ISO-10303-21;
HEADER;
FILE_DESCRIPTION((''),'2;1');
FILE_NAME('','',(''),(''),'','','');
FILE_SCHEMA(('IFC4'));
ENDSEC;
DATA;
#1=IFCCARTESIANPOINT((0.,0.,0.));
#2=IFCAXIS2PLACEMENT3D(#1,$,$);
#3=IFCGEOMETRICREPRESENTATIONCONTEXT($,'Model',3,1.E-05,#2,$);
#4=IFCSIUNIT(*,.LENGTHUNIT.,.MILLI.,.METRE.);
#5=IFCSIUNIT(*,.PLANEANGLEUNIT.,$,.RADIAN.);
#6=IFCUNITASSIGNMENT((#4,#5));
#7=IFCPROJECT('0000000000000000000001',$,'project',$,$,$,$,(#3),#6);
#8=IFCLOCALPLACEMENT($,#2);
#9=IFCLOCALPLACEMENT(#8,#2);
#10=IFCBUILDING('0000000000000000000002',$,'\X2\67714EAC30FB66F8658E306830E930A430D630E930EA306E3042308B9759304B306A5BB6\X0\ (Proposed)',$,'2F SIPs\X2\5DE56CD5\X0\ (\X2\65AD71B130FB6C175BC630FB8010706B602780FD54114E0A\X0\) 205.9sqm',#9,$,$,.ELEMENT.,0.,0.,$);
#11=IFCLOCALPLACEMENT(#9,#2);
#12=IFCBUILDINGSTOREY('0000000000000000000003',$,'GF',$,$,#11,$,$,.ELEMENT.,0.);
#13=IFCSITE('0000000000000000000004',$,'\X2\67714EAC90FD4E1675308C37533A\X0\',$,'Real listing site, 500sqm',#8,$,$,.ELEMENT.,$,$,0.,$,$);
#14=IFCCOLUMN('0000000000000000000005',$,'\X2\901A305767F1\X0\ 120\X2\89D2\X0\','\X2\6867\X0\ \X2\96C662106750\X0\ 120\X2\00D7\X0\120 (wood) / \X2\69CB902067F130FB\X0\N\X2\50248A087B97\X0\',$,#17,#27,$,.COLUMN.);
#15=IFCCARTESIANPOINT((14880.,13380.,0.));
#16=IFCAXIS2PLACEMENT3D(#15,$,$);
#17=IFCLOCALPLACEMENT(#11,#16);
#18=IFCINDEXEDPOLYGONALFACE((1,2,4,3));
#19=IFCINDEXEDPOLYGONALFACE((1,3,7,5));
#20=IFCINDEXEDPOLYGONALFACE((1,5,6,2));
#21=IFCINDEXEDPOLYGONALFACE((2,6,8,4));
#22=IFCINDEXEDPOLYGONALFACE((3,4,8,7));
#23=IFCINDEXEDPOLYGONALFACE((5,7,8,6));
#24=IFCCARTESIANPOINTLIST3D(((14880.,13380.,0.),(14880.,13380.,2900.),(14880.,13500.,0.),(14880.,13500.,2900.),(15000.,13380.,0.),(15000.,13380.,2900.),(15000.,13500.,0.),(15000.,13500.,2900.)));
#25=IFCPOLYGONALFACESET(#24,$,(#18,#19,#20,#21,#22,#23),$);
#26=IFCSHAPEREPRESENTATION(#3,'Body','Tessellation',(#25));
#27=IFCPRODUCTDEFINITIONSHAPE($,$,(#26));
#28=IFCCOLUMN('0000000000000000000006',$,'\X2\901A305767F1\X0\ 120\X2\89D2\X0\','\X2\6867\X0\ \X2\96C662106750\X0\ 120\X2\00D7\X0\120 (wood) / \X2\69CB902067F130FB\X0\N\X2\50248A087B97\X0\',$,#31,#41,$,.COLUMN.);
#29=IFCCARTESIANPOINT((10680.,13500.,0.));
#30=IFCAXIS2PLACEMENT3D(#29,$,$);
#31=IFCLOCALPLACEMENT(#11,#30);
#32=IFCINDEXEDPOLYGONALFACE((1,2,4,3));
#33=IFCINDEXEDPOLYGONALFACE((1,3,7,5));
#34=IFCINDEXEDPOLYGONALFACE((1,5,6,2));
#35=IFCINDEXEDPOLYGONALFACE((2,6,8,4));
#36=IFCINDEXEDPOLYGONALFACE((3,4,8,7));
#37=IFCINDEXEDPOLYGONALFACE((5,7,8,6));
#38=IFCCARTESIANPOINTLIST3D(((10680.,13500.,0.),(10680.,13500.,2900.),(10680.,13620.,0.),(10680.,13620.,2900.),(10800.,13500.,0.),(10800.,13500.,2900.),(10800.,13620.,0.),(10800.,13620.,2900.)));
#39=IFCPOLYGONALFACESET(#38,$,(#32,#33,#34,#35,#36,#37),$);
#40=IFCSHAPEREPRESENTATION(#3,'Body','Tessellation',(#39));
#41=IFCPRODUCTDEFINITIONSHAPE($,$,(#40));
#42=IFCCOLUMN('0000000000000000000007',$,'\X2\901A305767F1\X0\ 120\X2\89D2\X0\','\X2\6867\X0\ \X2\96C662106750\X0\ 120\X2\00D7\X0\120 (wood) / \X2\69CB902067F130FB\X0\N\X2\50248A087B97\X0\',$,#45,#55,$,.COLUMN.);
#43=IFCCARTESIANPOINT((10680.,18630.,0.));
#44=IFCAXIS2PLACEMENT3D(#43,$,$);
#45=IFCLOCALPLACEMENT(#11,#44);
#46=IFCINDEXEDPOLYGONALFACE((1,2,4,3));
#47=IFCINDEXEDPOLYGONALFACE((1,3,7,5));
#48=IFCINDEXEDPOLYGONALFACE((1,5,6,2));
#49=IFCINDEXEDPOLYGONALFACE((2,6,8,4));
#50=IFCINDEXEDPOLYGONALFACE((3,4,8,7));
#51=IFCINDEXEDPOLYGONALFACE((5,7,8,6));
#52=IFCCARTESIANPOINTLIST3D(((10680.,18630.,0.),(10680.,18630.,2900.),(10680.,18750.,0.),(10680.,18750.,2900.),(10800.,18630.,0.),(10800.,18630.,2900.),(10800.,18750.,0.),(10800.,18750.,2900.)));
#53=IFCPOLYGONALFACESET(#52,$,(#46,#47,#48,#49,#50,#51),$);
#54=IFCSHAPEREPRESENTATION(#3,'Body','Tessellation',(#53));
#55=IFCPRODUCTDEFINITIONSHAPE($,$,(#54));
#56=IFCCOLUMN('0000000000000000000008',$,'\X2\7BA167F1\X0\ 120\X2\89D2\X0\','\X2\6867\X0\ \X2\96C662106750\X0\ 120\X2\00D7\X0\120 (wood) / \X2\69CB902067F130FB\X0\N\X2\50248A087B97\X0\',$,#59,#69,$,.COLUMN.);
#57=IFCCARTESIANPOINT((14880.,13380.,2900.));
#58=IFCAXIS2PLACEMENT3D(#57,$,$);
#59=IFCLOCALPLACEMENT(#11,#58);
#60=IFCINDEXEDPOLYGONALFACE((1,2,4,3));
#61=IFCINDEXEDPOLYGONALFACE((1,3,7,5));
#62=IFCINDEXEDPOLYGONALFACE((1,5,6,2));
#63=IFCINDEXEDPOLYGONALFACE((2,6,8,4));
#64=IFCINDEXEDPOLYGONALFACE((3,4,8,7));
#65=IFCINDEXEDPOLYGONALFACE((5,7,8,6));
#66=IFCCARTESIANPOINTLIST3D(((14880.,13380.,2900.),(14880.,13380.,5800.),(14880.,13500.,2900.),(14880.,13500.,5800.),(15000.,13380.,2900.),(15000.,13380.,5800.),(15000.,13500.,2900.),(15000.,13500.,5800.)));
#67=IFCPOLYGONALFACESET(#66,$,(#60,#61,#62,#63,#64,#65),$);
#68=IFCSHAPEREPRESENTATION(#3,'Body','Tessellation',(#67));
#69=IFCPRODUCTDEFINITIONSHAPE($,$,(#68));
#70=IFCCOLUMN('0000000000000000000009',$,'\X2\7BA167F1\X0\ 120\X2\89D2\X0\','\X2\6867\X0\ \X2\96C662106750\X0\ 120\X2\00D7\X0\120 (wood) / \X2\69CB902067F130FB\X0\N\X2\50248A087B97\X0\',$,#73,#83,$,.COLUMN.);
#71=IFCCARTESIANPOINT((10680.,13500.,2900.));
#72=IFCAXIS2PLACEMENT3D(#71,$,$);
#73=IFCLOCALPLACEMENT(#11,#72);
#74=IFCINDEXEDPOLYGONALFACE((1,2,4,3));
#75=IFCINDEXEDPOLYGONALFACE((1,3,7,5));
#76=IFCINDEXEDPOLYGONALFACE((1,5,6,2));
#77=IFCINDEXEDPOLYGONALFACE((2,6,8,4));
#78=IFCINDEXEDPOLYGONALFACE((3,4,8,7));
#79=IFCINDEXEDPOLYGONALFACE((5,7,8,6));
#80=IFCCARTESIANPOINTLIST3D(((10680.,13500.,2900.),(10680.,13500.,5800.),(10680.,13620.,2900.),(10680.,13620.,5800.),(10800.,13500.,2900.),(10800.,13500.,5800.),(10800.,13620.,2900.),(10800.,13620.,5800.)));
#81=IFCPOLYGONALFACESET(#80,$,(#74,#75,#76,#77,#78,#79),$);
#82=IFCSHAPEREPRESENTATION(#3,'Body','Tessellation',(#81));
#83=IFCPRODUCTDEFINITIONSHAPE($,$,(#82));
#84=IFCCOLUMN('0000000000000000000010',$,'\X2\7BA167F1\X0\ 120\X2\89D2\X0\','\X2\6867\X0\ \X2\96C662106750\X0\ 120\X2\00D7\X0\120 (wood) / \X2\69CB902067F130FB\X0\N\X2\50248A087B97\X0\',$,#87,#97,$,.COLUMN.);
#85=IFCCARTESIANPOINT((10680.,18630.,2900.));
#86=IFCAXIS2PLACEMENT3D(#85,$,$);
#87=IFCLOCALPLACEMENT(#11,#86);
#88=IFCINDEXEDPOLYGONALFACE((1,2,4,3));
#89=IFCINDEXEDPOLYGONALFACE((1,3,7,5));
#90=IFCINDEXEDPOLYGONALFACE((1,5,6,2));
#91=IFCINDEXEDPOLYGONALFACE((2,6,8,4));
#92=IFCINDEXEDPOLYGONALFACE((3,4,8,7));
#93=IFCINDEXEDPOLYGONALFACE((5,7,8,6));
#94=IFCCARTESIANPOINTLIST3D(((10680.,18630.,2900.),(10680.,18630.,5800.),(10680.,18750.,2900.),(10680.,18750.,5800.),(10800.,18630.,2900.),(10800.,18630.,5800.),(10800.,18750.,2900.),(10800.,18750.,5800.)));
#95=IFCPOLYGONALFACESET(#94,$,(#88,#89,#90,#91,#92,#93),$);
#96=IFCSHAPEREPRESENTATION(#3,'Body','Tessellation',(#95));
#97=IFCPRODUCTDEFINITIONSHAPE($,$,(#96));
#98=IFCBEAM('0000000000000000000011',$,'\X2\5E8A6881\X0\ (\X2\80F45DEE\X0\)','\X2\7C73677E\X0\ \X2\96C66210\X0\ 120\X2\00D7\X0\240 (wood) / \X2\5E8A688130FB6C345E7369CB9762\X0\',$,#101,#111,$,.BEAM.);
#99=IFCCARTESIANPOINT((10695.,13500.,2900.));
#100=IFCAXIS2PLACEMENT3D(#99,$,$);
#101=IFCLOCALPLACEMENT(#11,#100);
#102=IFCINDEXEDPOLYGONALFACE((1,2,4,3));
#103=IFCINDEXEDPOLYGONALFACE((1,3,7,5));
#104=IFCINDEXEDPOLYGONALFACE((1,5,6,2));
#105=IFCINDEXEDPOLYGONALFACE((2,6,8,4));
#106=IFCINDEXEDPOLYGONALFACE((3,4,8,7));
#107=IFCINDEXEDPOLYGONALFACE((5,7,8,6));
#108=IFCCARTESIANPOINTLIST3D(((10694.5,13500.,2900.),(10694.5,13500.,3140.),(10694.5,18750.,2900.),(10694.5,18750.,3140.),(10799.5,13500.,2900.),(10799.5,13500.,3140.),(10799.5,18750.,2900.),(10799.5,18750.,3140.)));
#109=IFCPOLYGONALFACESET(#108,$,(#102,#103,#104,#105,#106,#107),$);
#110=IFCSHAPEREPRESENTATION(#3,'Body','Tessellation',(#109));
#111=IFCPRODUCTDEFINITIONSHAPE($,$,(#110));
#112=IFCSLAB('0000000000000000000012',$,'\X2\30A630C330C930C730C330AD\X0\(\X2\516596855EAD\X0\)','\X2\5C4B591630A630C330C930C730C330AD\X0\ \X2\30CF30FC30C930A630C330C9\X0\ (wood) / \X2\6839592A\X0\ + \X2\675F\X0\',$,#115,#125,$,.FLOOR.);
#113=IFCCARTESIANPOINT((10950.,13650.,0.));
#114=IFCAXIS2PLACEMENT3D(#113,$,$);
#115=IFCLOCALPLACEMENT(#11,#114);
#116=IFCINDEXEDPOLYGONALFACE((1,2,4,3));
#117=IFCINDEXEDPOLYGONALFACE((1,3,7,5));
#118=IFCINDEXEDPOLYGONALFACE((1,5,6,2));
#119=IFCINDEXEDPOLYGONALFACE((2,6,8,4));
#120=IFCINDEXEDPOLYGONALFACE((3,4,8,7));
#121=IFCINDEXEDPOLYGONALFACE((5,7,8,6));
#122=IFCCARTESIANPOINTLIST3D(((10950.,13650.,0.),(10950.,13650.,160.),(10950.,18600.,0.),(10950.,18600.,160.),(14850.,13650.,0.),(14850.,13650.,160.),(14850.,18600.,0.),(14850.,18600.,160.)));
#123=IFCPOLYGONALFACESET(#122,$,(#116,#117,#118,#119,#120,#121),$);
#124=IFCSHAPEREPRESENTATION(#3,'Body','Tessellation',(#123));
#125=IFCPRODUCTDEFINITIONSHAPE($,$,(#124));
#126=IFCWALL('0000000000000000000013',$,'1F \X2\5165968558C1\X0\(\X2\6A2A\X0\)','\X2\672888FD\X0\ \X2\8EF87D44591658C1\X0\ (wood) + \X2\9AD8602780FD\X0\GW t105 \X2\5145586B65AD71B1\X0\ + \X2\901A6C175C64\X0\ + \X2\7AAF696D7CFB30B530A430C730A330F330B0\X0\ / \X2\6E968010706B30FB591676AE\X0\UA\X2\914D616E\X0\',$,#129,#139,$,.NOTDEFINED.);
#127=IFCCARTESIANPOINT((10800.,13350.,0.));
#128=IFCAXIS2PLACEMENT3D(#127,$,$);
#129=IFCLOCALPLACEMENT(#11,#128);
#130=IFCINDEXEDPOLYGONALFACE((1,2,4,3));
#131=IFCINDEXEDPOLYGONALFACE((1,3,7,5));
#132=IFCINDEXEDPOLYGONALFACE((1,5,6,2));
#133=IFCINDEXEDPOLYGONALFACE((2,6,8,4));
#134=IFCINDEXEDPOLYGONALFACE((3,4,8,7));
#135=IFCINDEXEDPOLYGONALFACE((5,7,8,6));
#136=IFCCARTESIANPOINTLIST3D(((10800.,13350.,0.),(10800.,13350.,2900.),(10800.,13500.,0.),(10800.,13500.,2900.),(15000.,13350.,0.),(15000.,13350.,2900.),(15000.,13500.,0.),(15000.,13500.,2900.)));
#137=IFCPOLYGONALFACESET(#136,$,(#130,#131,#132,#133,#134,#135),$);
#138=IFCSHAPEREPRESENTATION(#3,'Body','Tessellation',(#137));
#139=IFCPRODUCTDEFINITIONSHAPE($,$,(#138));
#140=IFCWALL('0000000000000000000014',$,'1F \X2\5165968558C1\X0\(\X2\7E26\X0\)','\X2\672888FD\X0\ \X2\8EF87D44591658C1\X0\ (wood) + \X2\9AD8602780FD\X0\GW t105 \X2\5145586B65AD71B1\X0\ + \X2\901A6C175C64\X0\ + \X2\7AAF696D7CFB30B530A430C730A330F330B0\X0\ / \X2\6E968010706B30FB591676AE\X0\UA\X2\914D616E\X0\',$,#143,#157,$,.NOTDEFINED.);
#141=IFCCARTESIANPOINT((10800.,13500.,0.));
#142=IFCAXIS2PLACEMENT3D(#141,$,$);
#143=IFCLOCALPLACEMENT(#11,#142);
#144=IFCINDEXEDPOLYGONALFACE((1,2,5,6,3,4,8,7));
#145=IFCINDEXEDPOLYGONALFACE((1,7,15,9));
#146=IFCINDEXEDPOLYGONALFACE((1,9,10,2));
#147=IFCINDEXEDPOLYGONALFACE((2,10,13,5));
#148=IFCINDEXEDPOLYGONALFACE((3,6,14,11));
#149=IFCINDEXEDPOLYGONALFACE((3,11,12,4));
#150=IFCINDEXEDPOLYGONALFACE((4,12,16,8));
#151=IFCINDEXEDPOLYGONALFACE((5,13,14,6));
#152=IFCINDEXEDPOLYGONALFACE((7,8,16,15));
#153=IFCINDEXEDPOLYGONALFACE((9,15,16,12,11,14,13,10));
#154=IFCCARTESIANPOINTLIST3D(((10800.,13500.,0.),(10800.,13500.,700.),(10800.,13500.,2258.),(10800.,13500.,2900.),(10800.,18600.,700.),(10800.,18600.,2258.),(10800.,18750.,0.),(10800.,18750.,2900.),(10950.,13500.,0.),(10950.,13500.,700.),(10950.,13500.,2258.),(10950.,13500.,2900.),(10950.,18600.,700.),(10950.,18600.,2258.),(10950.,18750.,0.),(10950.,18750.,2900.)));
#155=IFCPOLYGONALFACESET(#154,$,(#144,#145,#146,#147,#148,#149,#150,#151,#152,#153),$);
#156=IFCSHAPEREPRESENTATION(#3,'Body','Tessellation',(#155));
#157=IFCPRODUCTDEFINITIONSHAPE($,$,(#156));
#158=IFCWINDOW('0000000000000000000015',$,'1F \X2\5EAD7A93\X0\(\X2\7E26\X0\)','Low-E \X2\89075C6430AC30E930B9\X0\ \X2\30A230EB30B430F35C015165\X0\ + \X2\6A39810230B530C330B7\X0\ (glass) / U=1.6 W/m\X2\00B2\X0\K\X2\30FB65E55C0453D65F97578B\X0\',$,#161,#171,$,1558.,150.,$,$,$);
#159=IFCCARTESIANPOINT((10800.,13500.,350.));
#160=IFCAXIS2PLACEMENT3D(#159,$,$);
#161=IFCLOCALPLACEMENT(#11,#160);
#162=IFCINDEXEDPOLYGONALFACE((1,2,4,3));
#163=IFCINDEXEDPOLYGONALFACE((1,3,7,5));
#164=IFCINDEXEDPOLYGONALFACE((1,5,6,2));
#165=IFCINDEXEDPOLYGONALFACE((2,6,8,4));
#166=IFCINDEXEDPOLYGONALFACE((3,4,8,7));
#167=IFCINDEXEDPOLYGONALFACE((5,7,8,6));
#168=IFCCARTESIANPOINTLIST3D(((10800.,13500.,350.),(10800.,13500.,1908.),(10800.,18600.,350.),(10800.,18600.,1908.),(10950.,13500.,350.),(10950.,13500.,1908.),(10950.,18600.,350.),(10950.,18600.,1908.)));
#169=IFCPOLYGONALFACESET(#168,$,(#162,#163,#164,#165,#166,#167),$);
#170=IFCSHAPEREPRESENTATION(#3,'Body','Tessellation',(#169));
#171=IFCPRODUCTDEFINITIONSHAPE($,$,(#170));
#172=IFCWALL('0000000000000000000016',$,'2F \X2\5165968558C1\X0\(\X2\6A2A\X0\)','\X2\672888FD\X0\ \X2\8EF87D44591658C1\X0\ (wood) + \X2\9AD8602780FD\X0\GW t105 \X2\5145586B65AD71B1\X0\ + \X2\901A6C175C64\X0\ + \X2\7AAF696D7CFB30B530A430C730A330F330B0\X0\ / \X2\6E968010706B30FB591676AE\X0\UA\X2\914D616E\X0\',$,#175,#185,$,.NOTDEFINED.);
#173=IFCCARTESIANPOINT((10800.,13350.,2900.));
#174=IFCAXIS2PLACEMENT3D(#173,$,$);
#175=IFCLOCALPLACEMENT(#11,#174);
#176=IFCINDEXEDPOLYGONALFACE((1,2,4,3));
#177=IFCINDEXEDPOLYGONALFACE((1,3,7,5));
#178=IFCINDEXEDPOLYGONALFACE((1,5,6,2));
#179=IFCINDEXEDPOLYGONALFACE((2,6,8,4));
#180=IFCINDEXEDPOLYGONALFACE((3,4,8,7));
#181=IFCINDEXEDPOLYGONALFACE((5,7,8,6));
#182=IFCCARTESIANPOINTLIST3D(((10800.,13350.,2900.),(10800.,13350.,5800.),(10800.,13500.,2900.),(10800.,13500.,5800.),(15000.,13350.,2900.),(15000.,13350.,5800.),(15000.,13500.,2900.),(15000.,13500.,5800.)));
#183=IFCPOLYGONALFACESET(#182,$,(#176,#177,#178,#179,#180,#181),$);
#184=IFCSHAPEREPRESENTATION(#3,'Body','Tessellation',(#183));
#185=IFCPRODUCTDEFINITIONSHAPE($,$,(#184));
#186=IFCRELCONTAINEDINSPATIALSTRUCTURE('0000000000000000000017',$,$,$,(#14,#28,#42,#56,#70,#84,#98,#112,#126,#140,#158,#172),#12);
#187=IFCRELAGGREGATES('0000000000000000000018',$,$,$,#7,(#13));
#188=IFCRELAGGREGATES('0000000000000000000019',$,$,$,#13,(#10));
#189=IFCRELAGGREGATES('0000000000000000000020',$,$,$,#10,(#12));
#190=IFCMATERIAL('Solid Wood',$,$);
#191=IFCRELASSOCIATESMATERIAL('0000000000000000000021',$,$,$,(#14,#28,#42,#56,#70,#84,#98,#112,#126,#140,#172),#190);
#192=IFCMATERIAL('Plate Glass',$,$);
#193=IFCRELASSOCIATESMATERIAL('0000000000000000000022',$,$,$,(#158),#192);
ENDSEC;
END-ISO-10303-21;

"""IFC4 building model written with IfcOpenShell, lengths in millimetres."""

from ifc_helpers import new_model, si_unit, frame, frame_2d, origin, place, context, project, spatial, rectangle, extrude, material, element, fill, save


model = new_model("IFC4")

# Units and contexts
model_context = context("Model", 3, precision=1e-05, world=origin())
ifc_project = project(units=[si_unit("LENGTHUNIT", "METRE", prefix="MILLI"), si_unit("PLANEANGLEUNIT", "RADIAN")], contexts=[model_context])

# Site, building, storey
site_placement = place(None, origin())
site = spatial("IfcSite", under=ifc_project, at=site_placement, Name="東京都世田谷区", ObjectType="Real listing site, 500sqm", CompositionType="ELEMENT", RefElevation=0.0)
building_placement = place(site_placement, origin())
building = spatial("IfcBuilding", under=site, at=building_placement, Name="東京・書斎とライブラリのある静かな家 (Proposed)", ObjectType="2F SIPs工法 (断熱・気密・耐火性能向上) 205.9sqm", CompositionType="ELEMENT", ElevationOfRefHeight=0.0, ElevationOfTerrain=0.0)
storey_placement = place(building_placement, origin())
storey = spatial("IfcBuildingStorey", under=building, at=storey_placement, Name="GF", CompositionType="ELEMENT", Elevation=0.0)

# Columns
ifc_material_1 = material(Name="Solid Wood")
column_1_placement = place(storey_placement, frame((14880.0, 13380.0, 0.0)))
element("IfcColumn", 1, at=column_1_placement, inside=storey, material=ifc_material_1, Name="通し柱 120角", Description="桧 集成材 120×120 (wood) / 構造柱・N値計算", PredefinedType="COLUMN", context=model_context, shape_type="SweptSolid", body=[
    extrude(rectangle(XDim=120.0, YDim=120.0, at=frame_2d((60.0, 60.0))), frame((14880.0, 13380.0, 0.0)), (0.0, 0.0, 1.0), 2900.0),
])
column_2_placement = place(storey_placement, frame((10680.0, 13500.0, 0.0)))
element("IfcColumn", 2, at=column_2_placement, inside=storey, material=ifc_material_1, Name="通し柱 120角", Description="桧 集成材 120×120 (wood) / 構造柱・N値計算", PredefinedType="COLUMN", context=model_context, shape_type="SweptSolid", body=[
    extrude(rectangle(XDim=120.0, YDim=120.0, at=frame_2d((60.0, 60.0))), frame((10680.0, 13500.0, 0.0)), (0.0, 0.0, 1.0), 2900.0),
])
column_3_placement = place(storey_placement, frame((10680.0, 18630.0, 0.0)))
element("IfcColumn", 3, at=column_3_placement, inside=storey, material=ifc_material_1, Name="通し柱 120角", Description="桧 集成材 120×120 (wood) / 構造柱・N値計算", PredefinedType="COLUMN", context=model_context, shape_type="SweptSolid", body=[
    extrude(rectangle(XDim=120.0, YDim=120.0, at=frame_2d((60.0, 60.0))), frame((10680.0, 18630.0, 0.0)), (0.0, 0.0, 1.0), 2900.0),
])
column_4_placement = place(storey_placement, frame((14880.0, 13380.0, 2900.0)))
element("IfcColumn", 4, at=column_4_placement, inside=storey, material=ifc_material_1, Name="管柱 120角", Description="桧 集成材 120×120 (wood) / 構造柱・N値計算", PredefinedType="COLUMN", context=model_context, shape_type="SweptSolid", body=[
    extrude(rectangle(XDim=120.0, YDim=120.0, at=frame_2d((60.0, 60.0))), frame((14880.0, 13380.0, 2900.0)), (0.0, 0.0, 1.0), 2900.0),
])
column_5_placement = place(storey_placement, frame((10680.0, 13500.0, 2900.0)))
element("IfcColumn", 5, at=column_5_placement, inside=storey, material=ifc_material_1, Name="管柱 120角", Description="桧 集成材 120×120 (wood) / 構造柱・N値計算", PredefinedType="COLUMN", context=model_context, shape_type="SweptSolid", body=[
    extrude(rectangle(XDim=120.0, YDim=120.0, at=frame_2d((60.0, 60.0))), frame((10680.0, 13500.0, 2900.0)), (0.0, 0.0, 1.0), 2900.0),
])
column_6_placement = place(storey_placement, frame((10680.0, 18630.0, 2900.0)))
element("IfcColumn", 6, at=column_6_placement, inside=storey, material=ifc_material_1, Name="管柱 120角", Description="桧 集成材 120×120 (wood) / 構造柱・N値計算", PredefinedType="COLUMN", context=model_context, shape_type="SweptSolid", body=[
    extrude(rectangle(XDim=120.0, YDim=120.0, at=frame_2d((60.0, 60.0))), frame((10680.0, 18630.0, 2900.0)), (0.0, 0.0, 1.0), 2900.0),
])

# Beam
beam_1_placement = place(storey_placement, frame((10695.0, 13500.0, 2900.0)))
element("IfcBeam", 7, at=beam_1_placement, inside=storey, material=ifc_material_1, Name="床梁 (胴差)", Description="米松 集成 120×240 (wood) / 床梁・水平構面", PredefinedType="BEAM", context=model_context, shape_type="SweptSolid", body=[
    extrude(rectangle(XDim=105.0, YDim=5250.0, at=frame_2d((52.0, 2625.0))), frame((10695.0, 13500.0, 2900.0)), (0.0, 0.0, 1.0), 240.0),
])

# Slab
slab_placement = place(storey_placement, frame((10950.0, 13650.0, 0.0)))
element("IfcSlab", 8, at=slab_placement, inside=storey, material=ifc_material_1, Name="ウッドデッキ(入隅庭)", Description="屋外ウッドデッキ ハードウッド (wood) / 根太 + 束", PredefinedType="FLOOR", context=model_context, shape_type="SweptSolid", body=[
    extrude(rectangle(XDim=3900.0, YDim=4950.0, at=frame_2d((1950.0, 2475.0))), frame((10950.0, 13650.0, 0.0)), (0.0, 0.0, 1.0), 160.0),
])

# Wall
wall_1_placement = place(storey_placement, frame((10800.0, 13350.0, 0.0)))
element("IfcWall", 9, at=wall_1_placement, inside=storey, material=ifc_material_1, Name="1F 入隅壁(横)", Description="木製 軸組外壁 (wood) + 高性能GW t105 充填断熱 + 通気層 + 窯業系サイディング / 準耐火・外皮UA配慮", PredefinedType="NOTDEFINED", context=model_context, shape_type="SweptSolid", body=[
    extrude(rectangle(XDim=4200.0, YDim=150.0, at=frame_2d((2100.0, 75.0))), frame((10800.0, 13350.0, 0.0)), (0.0, 0.0, 1.0), 2900.0),
])

# Wall, opening, window
wall_2_placement = place(storey_placement, frame((10800.0, 13500.0, 0.0)))
wall_2 = element("IfcWall", 10, at=wall_2_placement, inside=storey, material=ifc_material_1, Name="1F 入隅壁(縦)", Description="木製 軸組外壁 (wood) + 高性能GW t105 充填断熱 + 通気層 + 窯業系サイディング / 準耐火・外皮UA配慮", PredefinedType="NOTDEFINED", context=model_context, shape_type="SweptSolid", body=[
    extrude(rectangle(XDim=150.0, YDim=5250.0, at=frame_2d((75.0, 2625.0))), frame((10800.0, 13500.0, 0.0)), (0.0, 0.0, 1.0), 2900.0),
])
opening_1_placement = place(storey_placement, frame((10800.0, 13500.0, 350.0)))
opening_1 = element("IfcOpeningElement", 11, at=opening_1_placement, cuts=wall_2, PredefinedType="NOTDEFINED", context=model_context, shape_type="SweptSolid", body=[
    extrude(rectangle(XDim=150.0, YDim=5100.0, at=frame_2d((75.0, 2550.0))), frame((10800.0, 13500.0, 350.0)), (0.0, 0.0, 1.0), 1558.0),
])
ifc_material_2 = material(Name="Plate Glass")
window_1_placement = place(storey_placement, frame((10800.0, 13500.0, 350.0)))
window_1 = element("IfcWindow", 12, at=window_1_placement, inside=storey, material=ifc_material_2, Name="1F 庭窓(縦)", Description="Low-E 複層ガラス アルゴン封入 + 樹脂サッシ (glass) / U=1.6 W/m²K・日射取得型", OverallHeight=1558.0, OverallWidth=150.0, context=model_context, shape_type="SweptSolid", body=[
    extrude(rectangle(XDim=150.0, YDim=5100.0, at=frame_2d((75.0, 2550.0))), frame((10800.0, 13500.0, 350.0)), (0.0, 0.0, 1.0), 1558.0),
])
fill(opening_1, window_1)

# Wall
wall_3_placement = place(storey_placement, frame((10800.0, 13350.0, 2900.0)))
element("IfcWall", 13, at=wall_3_placement, inside=storey, material=ifc_material_1, Name="2F 入隅壁(横)", Description="木製 軸組外壁 (wood) + 高性能GW t105 充填断熱 + 通気層 + 窯業系サイディング / 準耐火・外皮UA配慮", PredefinedType="NOTDEFINED", context=model_context, shape_type="SweptSolid", body=[
    extrude(rectangle(XDim=4200.0, YDim=150.0, at=frame_2d((2100.0, 75.0))), frame((10800.0, 13350.0, 2900.0)), (0.0, 0.0, 1.0), 2900.0),
])

save(model, "model.ifc")
